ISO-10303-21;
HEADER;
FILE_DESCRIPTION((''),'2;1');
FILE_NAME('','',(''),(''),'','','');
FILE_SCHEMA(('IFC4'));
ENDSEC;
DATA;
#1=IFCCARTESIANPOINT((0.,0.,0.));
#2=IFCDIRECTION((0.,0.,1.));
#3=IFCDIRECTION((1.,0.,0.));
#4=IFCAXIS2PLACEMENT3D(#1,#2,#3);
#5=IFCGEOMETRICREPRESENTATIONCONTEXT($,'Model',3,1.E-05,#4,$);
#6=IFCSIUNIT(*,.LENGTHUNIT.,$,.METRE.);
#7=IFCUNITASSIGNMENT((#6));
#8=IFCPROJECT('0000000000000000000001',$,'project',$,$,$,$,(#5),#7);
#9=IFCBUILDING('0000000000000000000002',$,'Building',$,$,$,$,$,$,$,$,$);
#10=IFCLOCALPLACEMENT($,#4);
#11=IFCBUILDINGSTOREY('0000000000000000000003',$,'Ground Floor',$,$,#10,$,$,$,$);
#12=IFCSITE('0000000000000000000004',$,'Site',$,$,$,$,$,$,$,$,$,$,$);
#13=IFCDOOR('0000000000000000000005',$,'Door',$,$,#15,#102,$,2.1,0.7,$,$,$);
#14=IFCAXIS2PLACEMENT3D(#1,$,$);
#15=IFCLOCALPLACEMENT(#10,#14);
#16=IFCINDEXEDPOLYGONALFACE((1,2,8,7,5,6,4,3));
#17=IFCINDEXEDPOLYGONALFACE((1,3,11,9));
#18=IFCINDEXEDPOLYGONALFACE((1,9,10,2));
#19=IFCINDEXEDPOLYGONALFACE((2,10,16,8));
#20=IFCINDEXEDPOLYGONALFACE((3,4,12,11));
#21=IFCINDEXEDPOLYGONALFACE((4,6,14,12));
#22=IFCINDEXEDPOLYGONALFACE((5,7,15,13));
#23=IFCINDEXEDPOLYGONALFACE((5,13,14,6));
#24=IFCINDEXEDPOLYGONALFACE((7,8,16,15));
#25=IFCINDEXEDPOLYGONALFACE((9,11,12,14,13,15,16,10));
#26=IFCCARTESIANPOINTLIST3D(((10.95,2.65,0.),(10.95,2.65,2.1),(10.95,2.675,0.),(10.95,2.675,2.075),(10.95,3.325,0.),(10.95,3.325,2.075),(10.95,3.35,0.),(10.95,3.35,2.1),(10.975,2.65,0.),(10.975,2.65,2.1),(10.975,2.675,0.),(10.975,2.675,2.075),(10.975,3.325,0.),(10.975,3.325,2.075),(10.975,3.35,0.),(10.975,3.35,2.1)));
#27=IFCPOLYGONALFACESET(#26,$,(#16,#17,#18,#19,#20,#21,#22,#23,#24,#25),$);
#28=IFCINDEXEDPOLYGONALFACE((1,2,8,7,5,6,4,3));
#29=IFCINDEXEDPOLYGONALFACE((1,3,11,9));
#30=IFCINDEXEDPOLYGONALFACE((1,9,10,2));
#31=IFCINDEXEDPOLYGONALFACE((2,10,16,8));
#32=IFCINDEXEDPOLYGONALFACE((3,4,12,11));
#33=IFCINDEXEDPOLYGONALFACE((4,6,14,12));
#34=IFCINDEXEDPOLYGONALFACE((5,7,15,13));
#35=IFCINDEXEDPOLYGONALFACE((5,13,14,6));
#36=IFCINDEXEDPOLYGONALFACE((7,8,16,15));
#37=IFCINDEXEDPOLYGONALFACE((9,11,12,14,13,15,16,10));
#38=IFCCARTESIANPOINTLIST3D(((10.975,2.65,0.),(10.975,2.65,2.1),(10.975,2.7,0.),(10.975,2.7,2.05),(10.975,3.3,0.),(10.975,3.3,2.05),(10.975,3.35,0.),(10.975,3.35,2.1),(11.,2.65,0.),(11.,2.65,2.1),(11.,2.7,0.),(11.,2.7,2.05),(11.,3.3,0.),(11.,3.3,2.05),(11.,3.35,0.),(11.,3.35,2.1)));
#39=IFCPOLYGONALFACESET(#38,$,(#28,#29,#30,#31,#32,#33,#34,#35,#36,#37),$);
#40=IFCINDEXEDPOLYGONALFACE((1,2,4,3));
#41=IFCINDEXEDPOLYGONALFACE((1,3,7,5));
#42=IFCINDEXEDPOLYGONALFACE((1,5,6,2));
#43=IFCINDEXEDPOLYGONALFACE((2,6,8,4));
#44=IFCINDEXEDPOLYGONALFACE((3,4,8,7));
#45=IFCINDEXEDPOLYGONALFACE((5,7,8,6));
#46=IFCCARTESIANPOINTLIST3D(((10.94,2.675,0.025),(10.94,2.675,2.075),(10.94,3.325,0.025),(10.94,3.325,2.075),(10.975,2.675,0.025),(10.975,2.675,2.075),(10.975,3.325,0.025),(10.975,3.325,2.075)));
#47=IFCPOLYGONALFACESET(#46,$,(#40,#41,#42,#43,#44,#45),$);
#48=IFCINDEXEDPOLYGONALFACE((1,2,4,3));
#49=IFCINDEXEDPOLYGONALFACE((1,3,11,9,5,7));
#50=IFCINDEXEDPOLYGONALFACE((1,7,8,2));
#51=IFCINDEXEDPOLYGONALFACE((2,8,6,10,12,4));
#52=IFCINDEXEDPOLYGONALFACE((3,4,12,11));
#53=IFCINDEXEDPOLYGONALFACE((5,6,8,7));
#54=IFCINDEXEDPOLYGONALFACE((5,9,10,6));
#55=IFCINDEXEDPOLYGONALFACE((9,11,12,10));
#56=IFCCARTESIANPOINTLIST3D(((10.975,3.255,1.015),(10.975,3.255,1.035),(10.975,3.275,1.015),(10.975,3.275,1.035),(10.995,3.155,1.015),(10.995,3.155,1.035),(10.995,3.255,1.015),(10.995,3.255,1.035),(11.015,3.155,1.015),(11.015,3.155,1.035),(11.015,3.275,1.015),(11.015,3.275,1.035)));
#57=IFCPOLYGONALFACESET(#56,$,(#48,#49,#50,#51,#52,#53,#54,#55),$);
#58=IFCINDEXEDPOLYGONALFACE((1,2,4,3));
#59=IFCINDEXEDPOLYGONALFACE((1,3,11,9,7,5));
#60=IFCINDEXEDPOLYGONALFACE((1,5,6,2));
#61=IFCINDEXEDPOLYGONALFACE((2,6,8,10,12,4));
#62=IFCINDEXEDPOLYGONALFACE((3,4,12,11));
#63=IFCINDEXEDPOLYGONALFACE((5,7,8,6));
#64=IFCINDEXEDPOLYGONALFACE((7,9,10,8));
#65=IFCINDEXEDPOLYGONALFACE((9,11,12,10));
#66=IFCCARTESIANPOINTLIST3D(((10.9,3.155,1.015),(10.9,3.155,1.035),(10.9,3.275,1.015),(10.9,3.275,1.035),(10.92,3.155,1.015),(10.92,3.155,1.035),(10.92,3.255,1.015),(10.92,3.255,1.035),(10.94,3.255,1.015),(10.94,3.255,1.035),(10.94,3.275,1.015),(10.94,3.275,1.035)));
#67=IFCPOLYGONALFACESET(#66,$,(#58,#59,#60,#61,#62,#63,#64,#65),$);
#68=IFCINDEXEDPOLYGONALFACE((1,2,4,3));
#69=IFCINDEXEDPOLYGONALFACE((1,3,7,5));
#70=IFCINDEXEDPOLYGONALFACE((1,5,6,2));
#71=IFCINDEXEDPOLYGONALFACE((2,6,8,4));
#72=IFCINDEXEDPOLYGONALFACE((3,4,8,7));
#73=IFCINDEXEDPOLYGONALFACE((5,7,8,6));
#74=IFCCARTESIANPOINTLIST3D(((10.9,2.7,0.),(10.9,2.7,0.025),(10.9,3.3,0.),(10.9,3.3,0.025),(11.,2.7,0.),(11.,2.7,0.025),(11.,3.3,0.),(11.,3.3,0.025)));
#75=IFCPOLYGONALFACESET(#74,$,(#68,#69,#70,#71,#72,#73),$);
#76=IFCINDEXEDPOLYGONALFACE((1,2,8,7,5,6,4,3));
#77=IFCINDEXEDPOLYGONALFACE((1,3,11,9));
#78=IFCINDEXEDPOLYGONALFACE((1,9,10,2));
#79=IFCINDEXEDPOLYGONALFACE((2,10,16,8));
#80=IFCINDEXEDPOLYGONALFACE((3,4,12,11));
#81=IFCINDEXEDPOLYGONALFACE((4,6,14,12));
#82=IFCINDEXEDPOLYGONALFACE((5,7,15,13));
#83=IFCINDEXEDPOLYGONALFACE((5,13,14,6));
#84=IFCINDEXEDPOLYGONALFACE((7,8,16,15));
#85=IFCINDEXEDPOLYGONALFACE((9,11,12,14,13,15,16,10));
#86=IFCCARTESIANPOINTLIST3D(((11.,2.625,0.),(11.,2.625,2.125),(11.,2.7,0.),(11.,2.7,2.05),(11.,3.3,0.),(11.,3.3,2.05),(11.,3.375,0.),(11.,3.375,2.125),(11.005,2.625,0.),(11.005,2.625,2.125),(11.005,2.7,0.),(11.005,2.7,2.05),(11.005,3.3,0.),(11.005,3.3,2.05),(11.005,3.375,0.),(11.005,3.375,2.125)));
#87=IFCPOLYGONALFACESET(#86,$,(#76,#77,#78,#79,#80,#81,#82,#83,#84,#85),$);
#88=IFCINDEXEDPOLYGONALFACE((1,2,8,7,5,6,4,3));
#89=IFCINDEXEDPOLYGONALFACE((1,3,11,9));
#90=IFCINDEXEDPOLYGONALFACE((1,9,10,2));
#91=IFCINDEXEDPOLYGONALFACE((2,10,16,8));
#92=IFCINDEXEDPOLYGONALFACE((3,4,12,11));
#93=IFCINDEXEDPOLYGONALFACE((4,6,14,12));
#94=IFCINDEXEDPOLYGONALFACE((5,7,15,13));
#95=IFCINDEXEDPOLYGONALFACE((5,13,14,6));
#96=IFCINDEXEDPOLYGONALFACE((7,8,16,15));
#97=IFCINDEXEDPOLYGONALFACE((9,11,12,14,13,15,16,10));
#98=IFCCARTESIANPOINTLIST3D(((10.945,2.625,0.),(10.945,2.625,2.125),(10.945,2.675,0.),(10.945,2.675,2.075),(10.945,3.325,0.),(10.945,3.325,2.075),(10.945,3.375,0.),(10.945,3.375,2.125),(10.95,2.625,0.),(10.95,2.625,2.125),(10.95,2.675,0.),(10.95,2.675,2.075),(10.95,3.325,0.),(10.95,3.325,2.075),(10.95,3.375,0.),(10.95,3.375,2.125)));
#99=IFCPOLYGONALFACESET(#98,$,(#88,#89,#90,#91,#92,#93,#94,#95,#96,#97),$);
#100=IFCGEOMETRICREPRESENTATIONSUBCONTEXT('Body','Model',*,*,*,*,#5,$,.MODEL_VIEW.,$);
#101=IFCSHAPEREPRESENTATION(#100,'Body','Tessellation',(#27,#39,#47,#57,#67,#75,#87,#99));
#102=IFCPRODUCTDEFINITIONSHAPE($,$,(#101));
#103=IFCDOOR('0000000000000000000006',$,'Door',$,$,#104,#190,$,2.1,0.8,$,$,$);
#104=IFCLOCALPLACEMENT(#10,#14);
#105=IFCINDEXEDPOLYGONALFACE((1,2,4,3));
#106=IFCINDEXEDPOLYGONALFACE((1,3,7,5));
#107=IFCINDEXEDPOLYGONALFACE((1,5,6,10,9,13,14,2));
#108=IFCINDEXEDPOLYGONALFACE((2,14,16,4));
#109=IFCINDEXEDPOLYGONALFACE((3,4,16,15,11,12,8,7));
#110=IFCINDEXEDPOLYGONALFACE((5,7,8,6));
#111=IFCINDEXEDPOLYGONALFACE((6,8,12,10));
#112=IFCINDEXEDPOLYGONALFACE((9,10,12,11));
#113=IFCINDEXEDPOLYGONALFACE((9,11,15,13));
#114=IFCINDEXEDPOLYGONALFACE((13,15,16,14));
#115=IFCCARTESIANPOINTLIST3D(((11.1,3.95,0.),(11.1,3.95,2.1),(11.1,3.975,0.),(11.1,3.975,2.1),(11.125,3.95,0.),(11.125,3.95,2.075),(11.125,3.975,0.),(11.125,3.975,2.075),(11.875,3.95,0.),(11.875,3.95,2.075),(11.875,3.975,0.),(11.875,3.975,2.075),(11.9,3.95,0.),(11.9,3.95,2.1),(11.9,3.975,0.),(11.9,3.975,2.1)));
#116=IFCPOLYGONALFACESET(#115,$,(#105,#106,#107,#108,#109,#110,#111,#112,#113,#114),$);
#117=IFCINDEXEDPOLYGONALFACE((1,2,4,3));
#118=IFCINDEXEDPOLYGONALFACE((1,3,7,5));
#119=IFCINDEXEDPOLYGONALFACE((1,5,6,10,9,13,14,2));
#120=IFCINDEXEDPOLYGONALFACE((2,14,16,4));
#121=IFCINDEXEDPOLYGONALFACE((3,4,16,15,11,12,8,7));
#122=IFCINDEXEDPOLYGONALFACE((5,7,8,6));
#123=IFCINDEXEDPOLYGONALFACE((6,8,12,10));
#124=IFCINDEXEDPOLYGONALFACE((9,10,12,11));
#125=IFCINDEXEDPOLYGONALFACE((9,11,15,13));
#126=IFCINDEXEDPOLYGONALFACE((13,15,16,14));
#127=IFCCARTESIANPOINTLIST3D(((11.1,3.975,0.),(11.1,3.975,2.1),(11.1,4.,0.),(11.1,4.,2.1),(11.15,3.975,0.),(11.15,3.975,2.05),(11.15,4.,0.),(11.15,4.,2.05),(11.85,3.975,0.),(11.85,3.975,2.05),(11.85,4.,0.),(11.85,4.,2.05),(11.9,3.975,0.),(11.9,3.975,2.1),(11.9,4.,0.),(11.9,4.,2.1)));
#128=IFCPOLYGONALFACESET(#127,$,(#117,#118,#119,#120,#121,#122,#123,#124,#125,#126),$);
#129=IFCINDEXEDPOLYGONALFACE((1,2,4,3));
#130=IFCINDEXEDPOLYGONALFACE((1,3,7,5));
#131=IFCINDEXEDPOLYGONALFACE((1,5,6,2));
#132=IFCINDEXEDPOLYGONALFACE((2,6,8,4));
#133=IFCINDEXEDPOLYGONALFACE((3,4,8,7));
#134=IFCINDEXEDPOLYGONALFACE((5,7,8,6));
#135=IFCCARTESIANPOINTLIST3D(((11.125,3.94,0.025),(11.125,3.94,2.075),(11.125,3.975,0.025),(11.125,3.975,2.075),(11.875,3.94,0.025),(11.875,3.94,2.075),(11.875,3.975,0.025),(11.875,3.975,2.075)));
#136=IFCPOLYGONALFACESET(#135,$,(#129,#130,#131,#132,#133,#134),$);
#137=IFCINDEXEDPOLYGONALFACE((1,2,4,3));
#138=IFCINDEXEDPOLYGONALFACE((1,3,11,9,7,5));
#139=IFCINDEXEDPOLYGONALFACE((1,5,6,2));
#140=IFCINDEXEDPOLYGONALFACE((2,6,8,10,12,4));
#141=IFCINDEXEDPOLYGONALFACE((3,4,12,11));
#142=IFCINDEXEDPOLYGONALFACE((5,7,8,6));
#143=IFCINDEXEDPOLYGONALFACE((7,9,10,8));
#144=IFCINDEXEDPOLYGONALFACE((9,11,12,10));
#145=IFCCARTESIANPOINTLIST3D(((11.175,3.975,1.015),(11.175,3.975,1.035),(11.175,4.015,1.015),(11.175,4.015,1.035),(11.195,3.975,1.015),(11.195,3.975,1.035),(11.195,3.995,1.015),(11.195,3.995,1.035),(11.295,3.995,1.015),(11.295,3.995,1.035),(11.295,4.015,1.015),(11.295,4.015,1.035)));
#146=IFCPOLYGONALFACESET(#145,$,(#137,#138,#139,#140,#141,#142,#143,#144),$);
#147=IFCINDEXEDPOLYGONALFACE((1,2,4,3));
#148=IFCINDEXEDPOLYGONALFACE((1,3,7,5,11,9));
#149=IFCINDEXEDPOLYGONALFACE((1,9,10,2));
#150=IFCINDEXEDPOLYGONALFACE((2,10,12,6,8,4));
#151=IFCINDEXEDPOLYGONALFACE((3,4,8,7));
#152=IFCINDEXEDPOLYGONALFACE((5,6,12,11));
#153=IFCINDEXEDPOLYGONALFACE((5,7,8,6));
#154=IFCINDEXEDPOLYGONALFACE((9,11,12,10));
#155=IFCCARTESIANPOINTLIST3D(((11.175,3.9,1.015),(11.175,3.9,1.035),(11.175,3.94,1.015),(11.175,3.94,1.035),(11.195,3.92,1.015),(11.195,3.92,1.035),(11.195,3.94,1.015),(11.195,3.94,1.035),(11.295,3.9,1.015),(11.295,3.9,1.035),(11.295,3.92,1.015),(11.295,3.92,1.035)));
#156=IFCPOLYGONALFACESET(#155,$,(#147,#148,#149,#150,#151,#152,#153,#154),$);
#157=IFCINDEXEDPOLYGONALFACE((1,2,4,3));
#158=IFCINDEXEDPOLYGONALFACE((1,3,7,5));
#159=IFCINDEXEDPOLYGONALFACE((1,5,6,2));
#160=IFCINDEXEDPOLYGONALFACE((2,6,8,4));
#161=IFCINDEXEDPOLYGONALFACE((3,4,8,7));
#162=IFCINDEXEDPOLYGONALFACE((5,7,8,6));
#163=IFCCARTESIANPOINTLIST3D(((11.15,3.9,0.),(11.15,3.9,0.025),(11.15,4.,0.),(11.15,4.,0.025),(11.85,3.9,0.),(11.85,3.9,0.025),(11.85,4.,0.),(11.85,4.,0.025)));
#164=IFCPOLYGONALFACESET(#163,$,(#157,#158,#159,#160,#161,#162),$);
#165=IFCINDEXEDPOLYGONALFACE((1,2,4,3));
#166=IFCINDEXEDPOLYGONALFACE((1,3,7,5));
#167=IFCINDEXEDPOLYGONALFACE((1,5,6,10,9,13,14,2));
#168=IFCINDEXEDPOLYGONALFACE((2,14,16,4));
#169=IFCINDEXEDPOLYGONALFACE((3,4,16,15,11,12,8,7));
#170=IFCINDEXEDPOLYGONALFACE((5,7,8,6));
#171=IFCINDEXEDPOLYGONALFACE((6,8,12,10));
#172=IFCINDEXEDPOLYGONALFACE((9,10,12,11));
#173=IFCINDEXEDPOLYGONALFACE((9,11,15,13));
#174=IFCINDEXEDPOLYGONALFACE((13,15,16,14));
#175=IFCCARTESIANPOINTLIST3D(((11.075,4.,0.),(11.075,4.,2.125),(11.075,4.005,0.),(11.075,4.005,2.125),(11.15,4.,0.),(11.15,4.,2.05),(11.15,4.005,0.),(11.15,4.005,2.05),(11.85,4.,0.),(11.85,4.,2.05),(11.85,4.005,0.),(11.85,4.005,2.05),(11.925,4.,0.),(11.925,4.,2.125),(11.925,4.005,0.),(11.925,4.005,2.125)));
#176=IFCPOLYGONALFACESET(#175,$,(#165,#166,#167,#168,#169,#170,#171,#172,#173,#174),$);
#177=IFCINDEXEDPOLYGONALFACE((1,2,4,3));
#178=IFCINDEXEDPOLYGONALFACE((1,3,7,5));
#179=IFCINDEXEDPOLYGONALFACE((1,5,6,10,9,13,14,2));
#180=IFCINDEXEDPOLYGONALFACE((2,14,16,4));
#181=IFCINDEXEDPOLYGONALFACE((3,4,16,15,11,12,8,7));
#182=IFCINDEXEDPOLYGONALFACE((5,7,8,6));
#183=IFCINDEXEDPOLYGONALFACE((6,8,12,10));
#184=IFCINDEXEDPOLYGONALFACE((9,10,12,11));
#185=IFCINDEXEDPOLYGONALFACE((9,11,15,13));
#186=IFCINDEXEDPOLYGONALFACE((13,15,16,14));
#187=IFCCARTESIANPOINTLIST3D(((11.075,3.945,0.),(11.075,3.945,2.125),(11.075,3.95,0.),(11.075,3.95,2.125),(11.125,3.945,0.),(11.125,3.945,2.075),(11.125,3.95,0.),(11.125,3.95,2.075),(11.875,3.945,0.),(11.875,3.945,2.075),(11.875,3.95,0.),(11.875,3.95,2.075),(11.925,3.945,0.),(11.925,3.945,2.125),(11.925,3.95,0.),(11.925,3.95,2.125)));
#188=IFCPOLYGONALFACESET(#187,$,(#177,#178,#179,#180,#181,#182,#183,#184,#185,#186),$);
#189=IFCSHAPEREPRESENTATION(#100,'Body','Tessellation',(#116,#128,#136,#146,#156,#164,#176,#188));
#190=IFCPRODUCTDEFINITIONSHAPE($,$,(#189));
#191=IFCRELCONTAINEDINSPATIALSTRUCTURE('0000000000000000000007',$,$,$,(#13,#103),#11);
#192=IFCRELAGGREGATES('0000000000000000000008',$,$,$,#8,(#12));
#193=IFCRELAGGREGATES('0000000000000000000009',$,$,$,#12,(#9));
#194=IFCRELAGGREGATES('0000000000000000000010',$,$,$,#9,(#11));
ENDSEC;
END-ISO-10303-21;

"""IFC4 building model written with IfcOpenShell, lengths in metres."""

from ifc_helpers import new_model, si_unit, frame, origin_with_axes, place, context, subcontext, project, spatial, line, indexed_curve, outline, extrude, element, save


model = new_model("IFC4")

# Units and contexts
model_context = context("Model", 3, precision=1e-05, world=origin_with_axes())
body_context = subcontext(model_context, "Body", "Model", "MODEL_VIEW")
ifc_project = project(units=[si_unit("LENGTHUNIT", "METRE")], contexts=[model_context])

# Site, building, storey
site = spatial("IfcSite", under=ifc_project, Name="Site")
building = spatial("IfcBuilding", under=site, Name="Building")
storey_placement = place(None, origin_with_axes())
storey = spatial("IfcBuildingStorey", under=building, at=storey_placement, Name="Ground Floor")

# Doors
door_1_placement = place(storey_placement, frame((11.0, 2.65, 0.0), z_axis=(0.0, 0.0, 1.0), x_axis=(0.0, 1.0, 0.0)))
element("IfcDoor", 1, at=door_1_placement, inside=storey, Name="Door", OverallHeight=2.1, OverallWidth=0.7, context=body_context, shape_type="SweptSolid", body=[
    extrude(outline(indexed_curve([(0.0, 0.0), (0.0, 2.1), (0.7, 2.1), (0.7, 0.0), (0.675, 0.0), (0.675, 2.075), (0.025, 2.075), (0.025, 0.0)], segments=[line(1, 2, 3, 4, 5, 6, 7, 8, 1)])), frame((0.0, 0.025, 0.0), z_axis=(0.0, -1.0, 0.0), x_axis=(1.0, 0.0, 0.0)), (0.0, 0.0, -1.0), 0.025),
    extrude(outline(indexed_curve([(0.0, 0.0), (0.0, 2.1), (0.7, 2.1), (0.7, 0.0), (0.65, 0.0), (0.65, 2.05), (0.05, 2.05), (0.05, 0.0)], segments=[line(1, 2, 3, 4, 5, 6, 7, 8, 1)])), frame((0.0, 0.0, 0.0), z_axis=(0.0, -1.0, 0.0), x_axis=(1.0, 0.0, 0.0)), (0.0, 0.0, -1.0), 0.025),
    extrude(outline(indexed_curve([(0.0, 0.0), (0.65, 0.0), (0.65, 0.035), (0.0, 0.035)], segments=[line(1, 2, 3, 4, 1)])), frame((0.025, 0.025, 0.025), z_axis=(0.0, 0.0, 1.0), x_axis=(1.0, 0.0, 0.0)), (0.0, 0.0, 1.0), 2.05),
    extrude(outline(indexed_curve([(0.0, 0.0), (0.0, -0.04), (-0.12, -0.04), (-0.12, -0.02), (-0.02, -0.02), (-0.02, 0.0)], segments=[line(1, 2, 3, 4, 5, 6, 1)])), frame((0.625, 0.025, 1.015), z_axis=(0.0, 0.0, 1.0), x_axis=(1.0, 0.0, 0.0)), (0.0, 0.0, 1.0), 0.02),
    extrude(outline(indexed_curve([(0.0, 0.0), (0.0, 0.04), (-0.12, 0.04), (-0.12, 0.02), (-0.02, 0.02), (-0.02, 0.0)], segments=[line(1, 2, 3, 4, 5, 6, 1)])), frame((0.625, 0.06, 1.015), z_axis=(0.0, 0.0, 1.0), x_axis=(1.0, 0.0, 0.0)), (0.0, 0.0, 1.0), 0.02),
    extrude(outline(indexed_curve([(0.0, 0.0), (0.6, 0.0), (0.6, 0.1), (0.0, 0.1)], segments=[line(1, 2, 3, 4, 1)])), frame((0.05, 0.0, 0.0), z_axis=(0.0, 0.0, 1.0), x_axis=(1.0, 0.0, 0.0)), (0.0, 0.0, 1.0), 0.025),
    extrude(outline(indexed_curve([(0.0, 0.0), (0.0, 2.125), (0.75, 2.125), (0.75, 0.0), (0.675, 0.0), (0.675, 2.05), (0.075, 2.05), (0.075, 0.0)], segments=[line(1, 2, 3, 4, 5, 6, 7, 8, 1)])), frame((-0.025, -0.005, 0.0), z_axis=(0.0, -1.0, 0.0), x_axis=(1.0, 0.0, 0.0)), (0.0, 0.0, -1.0), 0.005),
    extrude(outline(indexed_curve([(0.0, 0.0), (0.0, 2.125), (0.75, 2.125), (0.75, 0.0), (0.7, 0.0), (0.7, 2.075), (0.05, 2.075), (0.05, 0.0)], segments=[line(1, 2, 3, 4, 5, 6, 7, 8, 1)])), frame((-0.025, 0.05, 0.0), z_axis=(0.0, -1.0, 0.0), x_axis=(1.0, 0.0, 0.0)), (0.0, 0.0, -1.0), 0.005),
])
door_2_placement = place(storey_placement, frame((11.9, 4.0, 0.0), z_axis=(0.0, 0.0, 1.0), x_axis=(-1.0, 0.0, 0.0)))
element("IfcDoor", 2, at=door_2_placement, inside=storey, Name="Door", OverallHeight=2.1, OverallWidth=0.8, context=body_context, shape_type="SweptSolid", body=[
    extrude(outline(indexed_curve([(0.0, 0.0), (0.0, 2.1), (0.8, 2.1), (0.8, 0.0), (0.775, 0.0), (0.775, 2.075), (0.025, 2.075), (0.025, 0.0)], segments=[line(1, 2, 3, 4, 5, 6, 7, 8, 1)])), frame((0.0, 0.025, 0.0), z_axis=(0.0, -1.0, 0.0), x_axis=(1.0, 0.0, 0.0)), (0.0, 0.0, -1.0), 0.025),
    extrude(outline(indexed_curve([(0.0, 0.0), (0.0, 2.1), (0.8, 2.1), (0.8, 0.0), (0.75, 0.0), (0.75, 2.05), (0.05, 2.05), (0.05, 0.0)], segments=[line(1, 2, 3, 4, 5, 6, 7, 8, 1)])), frame((0.0, 0.0, 0.0), z_axis=(0.0, -1.0, 0.0), x_axis=(1.0, 0.0, 0.0)), (0.0, 0.0, -1.0), 0.025),
    extrude(outline(indexed_curve([(0.0, 0.0), (0.75, 0.0), (0.75, 0.035), (0.0, 0.035)], segments=[line(1, 2, 3, 4, 1)])), frame((0.025, 0.025, 0.025), z_axis=(0.0, 0.0, 1.0), x_axis=(1.0, 0.0, 0.0)), (0.0, 0.0, 1.0), 2.05),
    extrude(outline(indexed_curve([(0.0, 0.0), (0.0, -0.04), (-0.12, -0.04), (-0.12, -0.02), (-0.02, -0.02), (-0.02, 0.0)], segments=[line(1, 2, 3, 4, 5, 6, 1)])), frame((0.725, 0.025, 1.015), z_axis=(0.0, 0.0, 1.0), x_axis=(1.0, 0.0, 0.0)), (0.0, 0.0, 1.0), 0.02),
    extrude(outline(indexed_curve([(0.0, 0.0), (0.0, 0.04), (-0.12, 0.04), (-0.12, 0.02), (-0.02, 0.02), (-0.02, 0.0)], segments=[line(1, 2, 3, 4, 5, 6, 1)])), frame((0.725, 0.06, 1.015), z_axis=(0.0, 0.0, 1.0), x_axis=(1.0, 0.0, 0.0)), (0.0, 0.0, 1.0), 0.02),
    extrude(outline(indexed_curve([(0.0, 0.0), (0.7, 0.0), (0.7, 0.1), (0.0, 0.1)], segments=[line(1, 2, 3, 4, 1)])), frame((0.05, 0.0, 0.0), z_axis=(0.0, 0.0, 1.0), x_axis=(1.0, 0.0, 0.0)), (0.0, 0.0, 1.0), 0.025),
    extrude(outline(indexed_curve([(0.0, 0.0), (0.0, 2.125), (0.85, 2.125), (0.85, 0.0), (0.775, 0.0), (0.775, 2.05), (0.075, 2.05), (0.075, 0.0)], segments=[line(1, 2, 3, 4, 5, 6, 7, 8, 1)])), frame((-0.025, -0.005, 0.0), z_axis=(0.0, -1.0, 0.0), x_axis=(1.0, 0.0, 0.0)), (0.0, 0.0, -1.0), 0.005),
    extrude(outline(indexed_curve([(0.0, 0.0), (0.0, 2.125), (0.85, 2.125), (0.85, 0.0), (0.8, 0.0), (0.8, 2.075), (0.05, 2.075), (0.05, 0.0)], segments=[line(1, 2, 3, 4, 5, 6, 7, 8, 1)])), frame((-0.025, 0.05, 0.0), z_axis=(0.0, -1.0, 0.0), x_axis=(1.0, 0.0, 0.0)), (0.0, 0.0, -1.0), 0.005),
])

save(model, "model.ifc")
